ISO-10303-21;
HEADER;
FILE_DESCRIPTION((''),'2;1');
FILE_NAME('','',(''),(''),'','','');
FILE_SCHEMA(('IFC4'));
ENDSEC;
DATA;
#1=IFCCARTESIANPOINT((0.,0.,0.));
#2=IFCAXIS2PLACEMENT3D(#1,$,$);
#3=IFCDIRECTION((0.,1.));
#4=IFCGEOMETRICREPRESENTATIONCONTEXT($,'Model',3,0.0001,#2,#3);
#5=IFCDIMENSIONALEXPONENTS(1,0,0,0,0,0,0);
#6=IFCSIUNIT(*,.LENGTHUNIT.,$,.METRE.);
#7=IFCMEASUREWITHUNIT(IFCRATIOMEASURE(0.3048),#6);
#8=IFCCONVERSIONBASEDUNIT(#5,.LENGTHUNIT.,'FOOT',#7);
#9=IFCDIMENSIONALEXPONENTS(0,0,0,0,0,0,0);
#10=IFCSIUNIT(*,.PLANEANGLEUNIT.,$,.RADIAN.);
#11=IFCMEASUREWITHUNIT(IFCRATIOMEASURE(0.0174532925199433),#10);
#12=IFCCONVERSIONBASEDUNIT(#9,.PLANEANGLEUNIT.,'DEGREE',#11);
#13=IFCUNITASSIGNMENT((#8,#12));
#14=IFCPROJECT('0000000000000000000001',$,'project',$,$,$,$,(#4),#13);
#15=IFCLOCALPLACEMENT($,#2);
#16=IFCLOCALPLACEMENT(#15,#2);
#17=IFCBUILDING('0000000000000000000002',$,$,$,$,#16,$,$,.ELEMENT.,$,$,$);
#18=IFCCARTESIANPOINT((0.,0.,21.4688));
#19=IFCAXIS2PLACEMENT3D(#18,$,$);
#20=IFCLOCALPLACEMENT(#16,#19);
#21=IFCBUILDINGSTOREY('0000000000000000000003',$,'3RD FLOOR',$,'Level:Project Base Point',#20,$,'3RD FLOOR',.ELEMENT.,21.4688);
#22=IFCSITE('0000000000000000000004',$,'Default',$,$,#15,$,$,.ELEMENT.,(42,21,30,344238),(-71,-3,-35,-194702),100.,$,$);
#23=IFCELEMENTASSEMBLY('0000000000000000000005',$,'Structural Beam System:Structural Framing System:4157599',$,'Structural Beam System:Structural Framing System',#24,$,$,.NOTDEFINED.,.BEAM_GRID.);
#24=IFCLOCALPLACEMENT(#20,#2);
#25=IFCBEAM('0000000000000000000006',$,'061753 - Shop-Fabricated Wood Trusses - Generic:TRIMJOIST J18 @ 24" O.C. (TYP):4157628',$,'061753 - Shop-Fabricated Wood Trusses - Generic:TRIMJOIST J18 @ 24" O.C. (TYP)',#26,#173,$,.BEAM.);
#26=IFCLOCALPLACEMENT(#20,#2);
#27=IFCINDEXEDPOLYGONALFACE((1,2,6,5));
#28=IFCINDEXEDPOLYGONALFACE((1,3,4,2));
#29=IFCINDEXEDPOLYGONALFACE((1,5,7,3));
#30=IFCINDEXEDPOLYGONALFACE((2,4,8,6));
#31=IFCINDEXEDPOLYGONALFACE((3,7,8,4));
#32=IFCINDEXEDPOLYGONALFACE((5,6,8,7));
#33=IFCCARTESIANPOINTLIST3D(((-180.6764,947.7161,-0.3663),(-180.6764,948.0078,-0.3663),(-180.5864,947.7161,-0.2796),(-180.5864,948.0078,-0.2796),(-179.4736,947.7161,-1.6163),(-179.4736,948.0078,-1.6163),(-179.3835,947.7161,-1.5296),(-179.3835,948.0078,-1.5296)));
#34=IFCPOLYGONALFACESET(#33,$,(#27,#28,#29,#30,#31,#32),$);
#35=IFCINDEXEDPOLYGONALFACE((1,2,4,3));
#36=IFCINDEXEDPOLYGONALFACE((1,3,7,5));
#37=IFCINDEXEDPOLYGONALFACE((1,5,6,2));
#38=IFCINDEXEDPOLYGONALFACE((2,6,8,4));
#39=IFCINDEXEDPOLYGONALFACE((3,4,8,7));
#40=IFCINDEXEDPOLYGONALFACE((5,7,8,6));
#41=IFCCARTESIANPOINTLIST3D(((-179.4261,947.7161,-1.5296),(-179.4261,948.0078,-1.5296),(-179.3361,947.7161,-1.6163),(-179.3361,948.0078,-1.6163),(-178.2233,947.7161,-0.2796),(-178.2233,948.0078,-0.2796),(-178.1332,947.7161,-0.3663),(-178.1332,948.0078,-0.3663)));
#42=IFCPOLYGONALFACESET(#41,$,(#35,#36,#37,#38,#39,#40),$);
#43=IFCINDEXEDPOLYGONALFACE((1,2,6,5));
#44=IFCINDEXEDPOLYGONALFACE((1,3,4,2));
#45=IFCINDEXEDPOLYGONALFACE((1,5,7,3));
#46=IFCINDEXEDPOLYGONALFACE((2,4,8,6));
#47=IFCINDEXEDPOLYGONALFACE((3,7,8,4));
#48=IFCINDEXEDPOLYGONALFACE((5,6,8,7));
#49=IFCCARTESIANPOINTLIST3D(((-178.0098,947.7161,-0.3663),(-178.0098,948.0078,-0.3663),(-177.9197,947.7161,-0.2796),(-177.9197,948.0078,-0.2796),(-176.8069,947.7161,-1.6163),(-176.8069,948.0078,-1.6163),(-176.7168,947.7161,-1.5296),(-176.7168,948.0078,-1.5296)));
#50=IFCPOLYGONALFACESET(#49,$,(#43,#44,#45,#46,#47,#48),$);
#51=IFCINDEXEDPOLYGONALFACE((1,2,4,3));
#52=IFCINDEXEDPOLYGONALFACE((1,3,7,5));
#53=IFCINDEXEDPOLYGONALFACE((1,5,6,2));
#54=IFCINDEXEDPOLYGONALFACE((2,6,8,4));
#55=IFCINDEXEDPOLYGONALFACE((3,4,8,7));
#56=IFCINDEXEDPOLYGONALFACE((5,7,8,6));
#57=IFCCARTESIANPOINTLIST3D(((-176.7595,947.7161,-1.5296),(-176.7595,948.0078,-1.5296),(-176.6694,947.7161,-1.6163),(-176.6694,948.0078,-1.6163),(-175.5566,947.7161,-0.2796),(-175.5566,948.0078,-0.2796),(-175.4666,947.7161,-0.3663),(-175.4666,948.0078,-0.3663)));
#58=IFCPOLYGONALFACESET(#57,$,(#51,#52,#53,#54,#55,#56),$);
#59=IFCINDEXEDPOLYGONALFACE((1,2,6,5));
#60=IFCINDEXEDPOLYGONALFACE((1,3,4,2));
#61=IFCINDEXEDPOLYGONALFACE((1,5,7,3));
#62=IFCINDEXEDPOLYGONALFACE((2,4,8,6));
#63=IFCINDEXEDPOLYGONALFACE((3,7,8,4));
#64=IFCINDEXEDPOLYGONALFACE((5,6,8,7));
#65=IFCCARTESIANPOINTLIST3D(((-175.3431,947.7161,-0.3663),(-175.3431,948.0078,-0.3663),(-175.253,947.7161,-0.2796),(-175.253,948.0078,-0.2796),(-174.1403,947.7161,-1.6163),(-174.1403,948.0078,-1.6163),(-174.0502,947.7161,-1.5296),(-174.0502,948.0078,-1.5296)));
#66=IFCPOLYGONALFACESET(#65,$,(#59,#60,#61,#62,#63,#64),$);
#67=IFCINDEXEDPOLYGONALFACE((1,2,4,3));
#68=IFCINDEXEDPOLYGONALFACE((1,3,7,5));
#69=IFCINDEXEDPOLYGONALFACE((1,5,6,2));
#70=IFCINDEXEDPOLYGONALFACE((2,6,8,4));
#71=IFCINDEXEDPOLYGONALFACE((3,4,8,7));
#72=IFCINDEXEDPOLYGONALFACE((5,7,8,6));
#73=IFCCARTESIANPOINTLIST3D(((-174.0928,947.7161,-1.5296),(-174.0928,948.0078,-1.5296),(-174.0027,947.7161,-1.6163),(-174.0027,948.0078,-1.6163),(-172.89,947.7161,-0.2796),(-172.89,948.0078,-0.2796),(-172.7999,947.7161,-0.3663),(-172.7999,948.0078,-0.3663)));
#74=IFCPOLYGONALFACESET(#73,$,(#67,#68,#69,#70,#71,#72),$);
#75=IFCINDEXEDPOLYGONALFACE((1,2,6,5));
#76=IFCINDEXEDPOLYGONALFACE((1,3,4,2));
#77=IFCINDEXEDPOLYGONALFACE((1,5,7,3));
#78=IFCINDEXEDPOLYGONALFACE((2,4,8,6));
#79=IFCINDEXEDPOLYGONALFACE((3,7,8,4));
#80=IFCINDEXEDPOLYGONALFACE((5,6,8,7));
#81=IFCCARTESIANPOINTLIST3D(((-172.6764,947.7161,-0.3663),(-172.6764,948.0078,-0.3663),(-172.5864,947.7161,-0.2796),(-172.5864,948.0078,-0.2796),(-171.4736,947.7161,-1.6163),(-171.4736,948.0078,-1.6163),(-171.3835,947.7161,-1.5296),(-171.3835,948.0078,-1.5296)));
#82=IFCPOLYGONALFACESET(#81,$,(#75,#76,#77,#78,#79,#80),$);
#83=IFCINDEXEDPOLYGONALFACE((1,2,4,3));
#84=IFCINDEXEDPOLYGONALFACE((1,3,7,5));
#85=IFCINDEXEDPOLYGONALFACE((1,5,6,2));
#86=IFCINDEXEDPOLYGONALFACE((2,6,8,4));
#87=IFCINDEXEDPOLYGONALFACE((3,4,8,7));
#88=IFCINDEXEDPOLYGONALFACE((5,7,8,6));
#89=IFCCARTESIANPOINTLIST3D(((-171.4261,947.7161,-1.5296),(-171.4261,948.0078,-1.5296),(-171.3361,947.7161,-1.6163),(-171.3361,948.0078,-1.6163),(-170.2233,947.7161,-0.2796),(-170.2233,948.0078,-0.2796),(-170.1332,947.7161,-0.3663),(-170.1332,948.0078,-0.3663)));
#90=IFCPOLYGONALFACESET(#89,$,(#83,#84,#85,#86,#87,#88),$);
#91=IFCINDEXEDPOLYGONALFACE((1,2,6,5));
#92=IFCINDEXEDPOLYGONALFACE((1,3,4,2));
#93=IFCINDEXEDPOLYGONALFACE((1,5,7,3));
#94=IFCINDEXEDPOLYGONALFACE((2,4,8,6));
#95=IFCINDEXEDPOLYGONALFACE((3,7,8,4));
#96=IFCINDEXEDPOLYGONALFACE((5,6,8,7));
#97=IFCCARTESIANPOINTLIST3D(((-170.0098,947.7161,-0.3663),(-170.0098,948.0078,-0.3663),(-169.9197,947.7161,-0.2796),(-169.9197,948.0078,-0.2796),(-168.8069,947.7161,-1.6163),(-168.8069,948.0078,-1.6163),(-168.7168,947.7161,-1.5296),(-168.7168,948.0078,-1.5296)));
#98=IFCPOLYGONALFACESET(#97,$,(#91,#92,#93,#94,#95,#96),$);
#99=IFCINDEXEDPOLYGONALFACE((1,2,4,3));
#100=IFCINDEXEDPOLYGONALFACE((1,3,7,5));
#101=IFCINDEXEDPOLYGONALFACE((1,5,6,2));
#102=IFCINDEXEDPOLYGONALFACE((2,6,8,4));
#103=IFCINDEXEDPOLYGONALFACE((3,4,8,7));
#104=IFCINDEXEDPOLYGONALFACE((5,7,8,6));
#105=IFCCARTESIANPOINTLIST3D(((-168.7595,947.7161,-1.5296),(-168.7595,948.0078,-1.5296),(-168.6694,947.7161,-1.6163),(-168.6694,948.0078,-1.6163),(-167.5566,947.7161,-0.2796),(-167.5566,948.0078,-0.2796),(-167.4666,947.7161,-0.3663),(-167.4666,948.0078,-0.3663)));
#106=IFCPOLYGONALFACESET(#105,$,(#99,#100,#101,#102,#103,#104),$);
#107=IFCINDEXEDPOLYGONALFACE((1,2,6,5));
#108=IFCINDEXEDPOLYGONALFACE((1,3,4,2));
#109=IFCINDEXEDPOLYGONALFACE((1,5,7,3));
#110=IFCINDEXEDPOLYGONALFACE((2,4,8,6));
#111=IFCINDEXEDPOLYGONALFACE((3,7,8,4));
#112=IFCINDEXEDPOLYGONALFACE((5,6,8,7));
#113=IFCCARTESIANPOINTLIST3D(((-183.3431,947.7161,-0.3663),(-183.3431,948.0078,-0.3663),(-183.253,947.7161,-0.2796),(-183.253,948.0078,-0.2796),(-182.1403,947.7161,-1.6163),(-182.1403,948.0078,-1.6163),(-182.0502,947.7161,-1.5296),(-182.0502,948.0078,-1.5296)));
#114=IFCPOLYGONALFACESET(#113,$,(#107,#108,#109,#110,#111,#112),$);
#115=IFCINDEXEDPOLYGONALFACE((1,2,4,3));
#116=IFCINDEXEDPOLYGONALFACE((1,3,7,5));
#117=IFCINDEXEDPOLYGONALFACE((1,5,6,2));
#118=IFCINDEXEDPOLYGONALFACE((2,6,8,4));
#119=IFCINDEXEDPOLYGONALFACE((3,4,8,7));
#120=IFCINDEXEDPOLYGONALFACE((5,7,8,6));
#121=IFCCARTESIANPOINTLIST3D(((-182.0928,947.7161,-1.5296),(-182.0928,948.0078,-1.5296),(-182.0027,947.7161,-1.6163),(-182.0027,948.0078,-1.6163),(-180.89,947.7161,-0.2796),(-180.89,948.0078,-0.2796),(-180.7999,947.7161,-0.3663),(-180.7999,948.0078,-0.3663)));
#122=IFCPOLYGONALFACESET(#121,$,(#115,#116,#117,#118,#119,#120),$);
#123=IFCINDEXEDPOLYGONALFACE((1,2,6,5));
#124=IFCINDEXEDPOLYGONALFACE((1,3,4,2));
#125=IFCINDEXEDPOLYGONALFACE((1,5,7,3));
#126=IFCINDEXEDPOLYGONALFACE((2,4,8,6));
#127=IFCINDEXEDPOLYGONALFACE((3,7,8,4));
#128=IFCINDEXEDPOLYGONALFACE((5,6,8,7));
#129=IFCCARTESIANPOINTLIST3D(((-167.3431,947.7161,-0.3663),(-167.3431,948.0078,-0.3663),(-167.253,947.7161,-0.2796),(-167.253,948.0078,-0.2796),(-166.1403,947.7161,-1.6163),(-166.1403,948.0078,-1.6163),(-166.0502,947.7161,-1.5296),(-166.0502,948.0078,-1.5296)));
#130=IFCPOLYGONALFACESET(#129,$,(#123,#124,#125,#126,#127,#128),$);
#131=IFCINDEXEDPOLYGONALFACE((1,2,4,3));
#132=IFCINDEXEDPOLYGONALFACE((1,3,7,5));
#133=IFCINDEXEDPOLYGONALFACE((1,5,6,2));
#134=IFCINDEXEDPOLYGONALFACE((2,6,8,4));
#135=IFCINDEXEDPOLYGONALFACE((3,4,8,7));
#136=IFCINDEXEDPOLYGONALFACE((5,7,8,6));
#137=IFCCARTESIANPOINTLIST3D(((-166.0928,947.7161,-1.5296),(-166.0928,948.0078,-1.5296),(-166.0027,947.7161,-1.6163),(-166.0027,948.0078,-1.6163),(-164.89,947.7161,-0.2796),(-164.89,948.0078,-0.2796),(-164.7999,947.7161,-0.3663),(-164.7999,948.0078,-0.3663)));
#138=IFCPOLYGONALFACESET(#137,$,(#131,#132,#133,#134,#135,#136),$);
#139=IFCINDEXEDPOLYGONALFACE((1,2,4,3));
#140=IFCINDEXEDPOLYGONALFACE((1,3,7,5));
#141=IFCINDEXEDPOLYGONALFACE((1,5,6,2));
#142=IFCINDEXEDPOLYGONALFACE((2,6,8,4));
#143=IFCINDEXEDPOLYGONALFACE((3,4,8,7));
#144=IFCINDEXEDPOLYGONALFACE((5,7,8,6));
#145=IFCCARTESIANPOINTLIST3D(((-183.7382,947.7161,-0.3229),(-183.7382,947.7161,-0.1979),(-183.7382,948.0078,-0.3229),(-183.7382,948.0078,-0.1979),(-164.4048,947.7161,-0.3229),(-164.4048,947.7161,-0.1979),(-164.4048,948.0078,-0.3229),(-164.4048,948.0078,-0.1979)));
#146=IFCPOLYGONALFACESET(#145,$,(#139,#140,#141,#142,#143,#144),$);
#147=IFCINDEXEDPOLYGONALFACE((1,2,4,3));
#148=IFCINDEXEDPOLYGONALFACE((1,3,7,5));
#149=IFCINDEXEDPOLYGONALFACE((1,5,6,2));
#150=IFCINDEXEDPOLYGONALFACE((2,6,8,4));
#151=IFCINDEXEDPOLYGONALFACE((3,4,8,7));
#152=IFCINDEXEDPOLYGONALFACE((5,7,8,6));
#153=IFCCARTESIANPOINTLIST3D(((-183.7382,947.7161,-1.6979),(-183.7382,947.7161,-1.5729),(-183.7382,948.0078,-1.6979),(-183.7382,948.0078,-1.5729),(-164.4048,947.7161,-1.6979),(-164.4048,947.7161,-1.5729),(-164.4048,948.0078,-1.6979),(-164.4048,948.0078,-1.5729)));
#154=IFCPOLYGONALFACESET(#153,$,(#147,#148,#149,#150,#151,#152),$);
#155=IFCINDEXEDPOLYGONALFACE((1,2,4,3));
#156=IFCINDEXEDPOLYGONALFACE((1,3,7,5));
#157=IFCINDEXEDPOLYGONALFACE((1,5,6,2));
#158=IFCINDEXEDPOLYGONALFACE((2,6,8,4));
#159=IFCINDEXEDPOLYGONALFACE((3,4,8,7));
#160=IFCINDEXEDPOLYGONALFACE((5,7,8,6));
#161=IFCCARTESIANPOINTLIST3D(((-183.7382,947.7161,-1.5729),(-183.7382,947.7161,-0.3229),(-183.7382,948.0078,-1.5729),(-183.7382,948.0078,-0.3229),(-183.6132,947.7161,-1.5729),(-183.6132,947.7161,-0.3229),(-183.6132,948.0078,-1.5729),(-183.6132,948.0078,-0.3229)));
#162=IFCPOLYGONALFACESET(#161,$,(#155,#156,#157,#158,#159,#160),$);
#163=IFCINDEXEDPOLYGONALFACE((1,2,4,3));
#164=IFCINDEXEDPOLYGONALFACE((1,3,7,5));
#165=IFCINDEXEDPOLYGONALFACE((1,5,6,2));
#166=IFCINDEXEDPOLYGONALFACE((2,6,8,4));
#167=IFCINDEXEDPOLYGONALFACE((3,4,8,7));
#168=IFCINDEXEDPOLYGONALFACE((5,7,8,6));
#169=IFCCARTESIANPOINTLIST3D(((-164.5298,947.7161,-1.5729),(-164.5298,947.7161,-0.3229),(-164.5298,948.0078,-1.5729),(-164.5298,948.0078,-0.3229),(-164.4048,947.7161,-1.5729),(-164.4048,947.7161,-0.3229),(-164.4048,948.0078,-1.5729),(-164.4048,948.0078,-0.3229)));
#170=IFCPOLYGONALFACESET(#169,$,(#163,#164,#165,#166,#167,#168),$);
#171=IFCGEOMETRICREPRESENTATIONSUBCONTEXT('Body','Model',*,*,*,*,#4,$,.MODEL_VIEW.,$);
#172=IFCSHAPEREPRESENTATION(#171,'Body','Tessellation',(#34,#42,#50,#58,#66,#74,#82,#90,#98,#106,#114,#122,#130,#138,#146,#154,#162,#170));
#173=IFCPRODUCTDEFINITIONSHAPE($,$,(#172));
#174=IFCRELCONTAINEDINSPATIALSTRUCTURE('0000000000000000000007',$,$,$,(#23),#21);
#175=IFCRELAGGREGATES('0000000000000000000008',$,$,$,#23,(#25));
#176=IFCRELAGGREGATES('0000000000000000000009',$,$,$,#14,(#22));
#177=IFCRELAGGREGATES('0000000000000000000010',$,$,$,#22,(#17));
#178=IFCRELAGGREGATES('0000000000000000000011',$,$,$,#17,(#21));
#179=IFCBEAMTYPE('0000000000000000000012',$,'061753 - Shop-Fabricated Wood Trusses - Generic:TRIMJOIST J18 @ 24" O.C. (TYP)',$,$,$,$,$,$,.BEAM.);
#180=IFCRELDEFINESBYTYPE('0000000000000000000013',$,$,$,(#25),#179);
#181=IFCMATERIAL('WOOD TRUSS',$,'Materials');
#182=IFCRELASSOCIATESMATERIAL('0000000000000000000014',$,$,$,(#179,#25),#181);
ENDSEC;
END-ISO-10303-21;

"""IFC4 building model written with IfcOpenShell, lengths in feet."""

from ifc_helpers import new_model, entity, si_unit, converted_unit, direction, frame, frame_2d, origin, origin_2d_with_axis, place, context, subcontext, project, spatial, rectangle, extrude, source, transform, mapped, material, material_profile, profile_set, profile_usage, type_object, type_shapes, element, aggregate, save


model = new_model("IFC4")

# Units and contexts
model_context = context("Model", 3, precision=0.0001, world=origin(), true_north=direction((0.0, 1.0)))
body_context = subcontext(model_context, "Body", "Model", "MODEL_VIEW")
ifc_project = project(units=[converted_unit("LENGTHUNIT", "FOOT", entity("IfcRatioMeasure", 0.3048), si_unit("LENGTHUNIT", "METRE"), dimensions=[1, 0, 0, 0, 0, 0, 0]), converted_unit("PLANEANGLEUNIT", "DEGREE", entity("IfcRatioMeasure", 0.0174532925199433), si_unit("PLANEANGLEUNIT", "RADIAN"), dimensions=[0, 0, 0, 0, 0, 0, 0])], contexts=[model_context])

# Site, building, storey
site_placement = place(None, origin())
site = spatial("IfcSite", under=ifc_project, at=site_placement, Name="Default", CompositionType="ELEMENT", RefLatitude=(42, 21, 30, 344238), RefLongitude=(-71, -3, -35, -194702), RefElevation=100.0)
building_placement = place(site_placement, origin())
building = spatial("IfcBuilding", under=site, at=building_placement, CompositionType="ELEMENT")
storey_placement = place(building_placement, frame((0.0, 0.0, 21.4688)))
storey = spatial("IfcBuildingStorey", under=building, at=storey_placement, Name="3RD FLOOR", ObjectType="Level:Project Base Point", LongName="3RD FLOOR", CompositionType="ELEMENT", Elevation=21.4688)

# Element assembly, beam
ifc_material = material(Name="WOOD TRUSS", Category="Materials")
ifc_material_profile_1 = material_profile(ifc_material, rectangle(XDim=1.7347, YDim=0.125, at=frame_2d((0.0, 0.0), x_axis=(1.0, 0.0))), Name="TRIMJOIST J18 @ 24\" O.C. (TYP)")
ifc_material_profile_2 = material_profile(ifc_material, rectangle(XDim=1.7347, YDim=0.125, at=frame_2d((0.0, 0.0), x_axis=(1.0, 0.0))), Name="TRIMJOIST J18 @ 24\" O.C. (TYP)")
ifc_material_profile_3 = material_profile(ifc_material, rectangle(XDim=1.7347, YDim=0.125, at=frame_2d((0.0, 0.0), x_axis=(1.0, 0.0))), Name="TRIMJOIST J18 @ 24\" O.C. (TYP)")
ifc_material_profile_4 = material_profile(ifc_material, rectangle(XDim=1.7347, YDim=0.125, at=frame_2d((0.0, 0.0), x_axis=(1.0, 0.0))), Name="TRIMJOIST J18 @ 24\" O.C. (TYP)")
ifc_material_profile_5 = material_profile(ifc_material, rectangle(XDim=1.7347, YDim=0.125, at=frame_2d((0.0, 0.0), x_axis=(1.0, 0.0))), Name="TRIMJOIST J18 @ 24\" O.C. (TYP)")
ifc_material_profile_6 = material_profile(ifc_material, rectangle(XDim=1.7347, YDim=0.125, at=frame_2d((0.0, 0.0), x_axis=(1.0, 0.0))), Name="TRIMJOIST J18 @ 24\" O.C. (TYP)")
ifc_material_profile_7 = material_profile(ifc_material, rectangle(XDim=1.7347, YDim=0.125, at=frame_2d((0.0, 0.0), x_axis=(1.0, 0.0))), Name="TRIMJOIST J18 @ 24\" O.C. (TYP)")
ifc_material_profile_8 = material_profile(ifc_material, rectangle(XDim=1.7347, YDim=0.125, at=frame_2d((0.0, 0.0), x_axis=(1.0, 0.0))), Name="TRIMJOIST J18 @ 24\" O.C. (TYP)")
ifc_material_profile_9 = material_profile(ifc_material, rectangle(XDim=1.7347, YDim=0.125, at=frame_2d((0.0, 0.0), x_axis=(1.0, 0.0))), Name="TRIMJOIST J18 @ 24\" O.C. (TYP)")
ifc_material_profile_10 = material_profile(ifc_material, rectangle(XDim=1.7347, YDim=0.125, at=origin_2d_with_axis()), Name="TRIMJOIST J18 @ 24\" O.C. (TYP)")
ifc_material_profile_11 = material_profile(ifc_material, rectangle(XDim=0.125, YDim=0.2917, at=origin_2d_with_axis()), Name="TRIMJOIST J18 @ 24\" O.C. (TYP)")
ifc_material_profile_12 = material_profile(ifc_material, rectangle(XDim=0.125, YDim=0.2917, at=origin_2d_with_axis()), Name="TRIMJOIST J18 @ 24\" O.C. (TYP)")
ifc_material_profile_13 = material_profile(ifc_material, rectangle(XDim=1.25, YDim=0.2917, at=origin_2d_with_axis()), Name="TRIMJOIST J18 @ 24\" O.C. (TYP)")
ifc_material_profile_14 = material_profile(ifc_material, rectangle(XDim=1.25, YDim=0.2917, at=origin_2d_with_axis()), Name="TRIMJOIST J18 @ 24\" O.C. (TYP)")
ifc_profile_set = profile_set([ifc_material_profile_1, ifc_material_profile_2, ifc_material_profile_3, ifc_material_profile_4, ifc_material_profile_5, ifc_material_profile_6, ifc_material_profile_7, ifc_material_profile_8, ifc_material_profile_9, ifc_material_profile_10, ifc_material_profile_11, ifc_material_profile_12, ifc_material_profile_13, ifc_material_profile_14], Name="TRIMJOIST J18 @ 24\" O.C. (TYP)")
assembly_1_placement = place(storey_placement, origin())
assembly_1 = element("IfcElementAssembly", 1, at=assembly_1_placement, inside=storey, Name="Structural Beam System:Structural Framing System:4157599", ObjectType="Structural Beam System:Structural Framing System", AssemblyPlace="NOTDEFINED", PredefinedType="BEAM_GRID")
beam_type_1 = type_object("IfcBeamType", Name="061753 - Shop-Fabricated Wood Trusses - Generic:TRIMJOIST J18 @ 24\" O.C. (TYP)", PredefinedType="BEAM", material=ifc_profile_set)
shared_shape_1 = source(origin(), body_context, "Body", "SweptSolid", [
    extrude(rectangle(XDim=1.7347, YDim=0.125, at=frame_2d((0.0, 0.0), x_axis=(1.0, 0.0))), frame((5.9585, -0.1458, 0.0), z_axis=(0.0, 1.0, 0.0), x_axis=(0.693383, 0.0, 0.720569)), (0.0, 0.0, 1.0), 0.2917),
    extrude(rectangle(XDim=1.7347, YDim=0.125, at=origin_2d_with_axis()), frame((4.7082, -0.1458, 0.0), z_axis=(0.0, 1.0, 0.0), x_axis=(0.693383, 0.0, -0.720569)), (0.0, 0.0, 1.0), 0.2917),
    extrude(rectangle(XDim=1.7347, YDim=0.125, at=frame_2d((0.0, 0.0), x_axis=(1.0, 0.0))), frame((3.2918, -0.1458, 0.0), z_axis=(0.0, 1.0, 0.0), x_axis=(0.693383, 0.0, 0.720569)), (0.0, 0.0, 1.0), 0.2917),
    extrude(rectangle(XDim=1.7347, YDim=0.125, at=frame_2d((0.0, 0.0), x_axis=(1.0, 0.0))), frame((2.0415, -0.1458, 0.0), z_axis=(0.0, 1.0, 0.0), x_axis=(0.693383, 0.0, -0.720569)), (0.0, 0.0, 1.0), 0.2917),
    extrude(rectangle(XDim=1.7347, YDim=0.125, at=frame_2d((0.0, 0.0), x_axis=(1.0, 0.0))), frame((0.6251, -0.1458, 0.0), z_axis=(0.0, 1.0, 0.0), x_axis=(0.693383, 0.0, 0.720569)), (0.0, 0.0, 1.0), 0.2917),
    extrude(rectangle(XDim=1.7347, YDim=0.125, at=frame_2d((0.0, 0.0), x_axis=(1.0, 0.0))), frame((-0.6251, -0.1458, 0.0), z_axis=(0.0, 1.0, 0.0), x_axis=(0.693383, 0.0, -0.720569)), (0.0, 0.0, 1.0), 0.2917),
    extrude(rectangle(XDim=1.7347, YDim=0.125, at=frame_2d((0.0, 0.0), x_axis=(1.0, 0.0))), frame((-2.0415, -0.1458, 0.0), z_axis=(0.0, 1.0, 0.0), x_axis=(0.693383, 0.0, 0.720569)), (0.0, 0.0, 1.0), 0.2917),
    extrude(rectangle(XDim=1.7347, YDim=0.125, at=origin_2d_with_axis()), frame((-3.2918, -0.1458, 0.0), z_axis=(0.0, 1.0, 0.0), x_axis=(0.693383, 0.0, -0.720569)), (0.0, 0.0, 1.0), 0.2917),
    extrude(rectangle(XDim=1.7347, YDim=0.125, at=frame_2d((0.0, 0.0), x_axis=(1.0, 0.0))), frame((-4.7082, -0.1458, 0.0), z_axis=(0.0, 1.0, 0.0), x_axis=(0.693383, 0.0, 0.720569)), (0.0, 0.0, 1.0), 0.2917),
    extrude(rectangle(XDim=1.7347, YDim=0.125, at=frame_2d((0.0, 0.0), x_axis=(1.0, 0.0))), frame((-5.9585, -0.1458, 0.0), z_axis=(0.0, 1.0, 0.0), x_axis=(0.693383, 0.0, -0.720569)), (0.0, 0.0, 1.0), 0.2917),
    extrude(rectangle(XDim=1.7347, YDim=0.125, at=frame_2d((0.0, 0.0), x_axis=(1.0, 0.0))), frame((8.6251, -0.1458, 0.0), z_axis=(0.0, 1.0, 0.0), x_axis=(0.693383, 0.0, 0.720569)), (0.0, 0.0, 1.0), 0.2917),
    extrude(rectangle(XDim=1.7347, YDim=0.125, at=origin_2d_with_axis()), frame((7.3749, -0.1458, 0.0), z_axis=(0.0, 1.0, 0.0), x_axis=(0.693383, 0.0, -0.720569)), (0.0, 0.0, 1.0), 0.2917),
    extrude(rectangle(XDim=1.7347, YDim=0.125, at=frame_2d((0.0, 0.0), x_axis=(1.0, 0.0))), frame((-7.3749, -0.1458, 0.0), z_axis=(0.0, 1.0, 0.0), x_axis=(0.693383, 0.0, 0.720569)), (0.0, 0.0, 1.0), 0.2917),
    extrude(rectangle(XDim=1.7347, YDim=0.125, at=origin_2d_with_axis()), frame((-8.6251, -0.1458, 0.0), z_axis=(0.0, 1.0, 0.0), x_axis=(0.693383, 0.0, -0.720569)), (0.0, 0.0, 1.0), 0.2917),
    extrude(rectangle(XDim=0.125, YDim=0.2917, at=origin_2d_with_axis()), frame((-9.6667, 0.0, 0.6875), z_axis=(1.0, 0.0, 0.0), x_axis=(0.0, 0.0, -1.0)), (0.0, 0.0, 1.0), 19.3333),
    extrude(rectangle(XDim=0.125, YDim=0.2917, at=origin_2d_with_axis()), frame((-9.6667, 0.0, -0.6875), z_axis=(1.0, 0.0, 0.0), x_axis=(0.0, 0.0, -1.0)), (0.0, 0.0, 1.0), 19.3333),
    extrude(rectangle(XDim=1.25, YDim=0.2917, at=origin_2d_with_axis()), frame((9.5417, 0.0, 0.0), z_axis=(1.0, 0.0, 0.0), x_axis=(0.0, 0.0, -1.0)), (0.0, 0.0, 1.0), 0.125),
    extrude(rectangle(XDim=1.25, YDim=0.2917, at=origin_2d_with_axis()), frame((-9.6667, 0.0, 0.0), z_axis=(1.0, 0.0, 0.0), x_axis=(0.0, 0.0, -1.0)), (0.0, 0.0, 1.0), 0.125),
])
type_shapes(beam_type_1, [shared_shape_1])
ifc_profile_usage_1 = profile_usage(ifc_profile_set, cardinal=8)
beam_1_placement = place(assembly_1_placement, frame((-174.0715, 947.8619, -0.9479), z_axis=(0.0, 0.0, 1.0), x_axis=(-1.0, 0.0, 0.0)))
beam_1 = element("IfcBeam", 2, at=beam_1_placement, type_object=beam_type_1, material=ifc_profile_usage_1, Name="061753 - Shop-Fabricated Wood Trusses - Generic:TRIMJOIST J18 @ 24\" O.C. (TYP):4157628", ObjectType="061753 - Shop-Fabricated Wood Trusses - Generic:TRIMJOIST J18 @ 24\" O.C. (TYP)", PredefinedType="BEAM", context=body_context, shape_type="MappedRepresentation", body=[
    mapped(shared_shape_1, transform((0.0, 0.0, 0.0), scale=1.0)),
])
aggregate(assembly_1, [beam_1])

save(model, "model.ifc")
